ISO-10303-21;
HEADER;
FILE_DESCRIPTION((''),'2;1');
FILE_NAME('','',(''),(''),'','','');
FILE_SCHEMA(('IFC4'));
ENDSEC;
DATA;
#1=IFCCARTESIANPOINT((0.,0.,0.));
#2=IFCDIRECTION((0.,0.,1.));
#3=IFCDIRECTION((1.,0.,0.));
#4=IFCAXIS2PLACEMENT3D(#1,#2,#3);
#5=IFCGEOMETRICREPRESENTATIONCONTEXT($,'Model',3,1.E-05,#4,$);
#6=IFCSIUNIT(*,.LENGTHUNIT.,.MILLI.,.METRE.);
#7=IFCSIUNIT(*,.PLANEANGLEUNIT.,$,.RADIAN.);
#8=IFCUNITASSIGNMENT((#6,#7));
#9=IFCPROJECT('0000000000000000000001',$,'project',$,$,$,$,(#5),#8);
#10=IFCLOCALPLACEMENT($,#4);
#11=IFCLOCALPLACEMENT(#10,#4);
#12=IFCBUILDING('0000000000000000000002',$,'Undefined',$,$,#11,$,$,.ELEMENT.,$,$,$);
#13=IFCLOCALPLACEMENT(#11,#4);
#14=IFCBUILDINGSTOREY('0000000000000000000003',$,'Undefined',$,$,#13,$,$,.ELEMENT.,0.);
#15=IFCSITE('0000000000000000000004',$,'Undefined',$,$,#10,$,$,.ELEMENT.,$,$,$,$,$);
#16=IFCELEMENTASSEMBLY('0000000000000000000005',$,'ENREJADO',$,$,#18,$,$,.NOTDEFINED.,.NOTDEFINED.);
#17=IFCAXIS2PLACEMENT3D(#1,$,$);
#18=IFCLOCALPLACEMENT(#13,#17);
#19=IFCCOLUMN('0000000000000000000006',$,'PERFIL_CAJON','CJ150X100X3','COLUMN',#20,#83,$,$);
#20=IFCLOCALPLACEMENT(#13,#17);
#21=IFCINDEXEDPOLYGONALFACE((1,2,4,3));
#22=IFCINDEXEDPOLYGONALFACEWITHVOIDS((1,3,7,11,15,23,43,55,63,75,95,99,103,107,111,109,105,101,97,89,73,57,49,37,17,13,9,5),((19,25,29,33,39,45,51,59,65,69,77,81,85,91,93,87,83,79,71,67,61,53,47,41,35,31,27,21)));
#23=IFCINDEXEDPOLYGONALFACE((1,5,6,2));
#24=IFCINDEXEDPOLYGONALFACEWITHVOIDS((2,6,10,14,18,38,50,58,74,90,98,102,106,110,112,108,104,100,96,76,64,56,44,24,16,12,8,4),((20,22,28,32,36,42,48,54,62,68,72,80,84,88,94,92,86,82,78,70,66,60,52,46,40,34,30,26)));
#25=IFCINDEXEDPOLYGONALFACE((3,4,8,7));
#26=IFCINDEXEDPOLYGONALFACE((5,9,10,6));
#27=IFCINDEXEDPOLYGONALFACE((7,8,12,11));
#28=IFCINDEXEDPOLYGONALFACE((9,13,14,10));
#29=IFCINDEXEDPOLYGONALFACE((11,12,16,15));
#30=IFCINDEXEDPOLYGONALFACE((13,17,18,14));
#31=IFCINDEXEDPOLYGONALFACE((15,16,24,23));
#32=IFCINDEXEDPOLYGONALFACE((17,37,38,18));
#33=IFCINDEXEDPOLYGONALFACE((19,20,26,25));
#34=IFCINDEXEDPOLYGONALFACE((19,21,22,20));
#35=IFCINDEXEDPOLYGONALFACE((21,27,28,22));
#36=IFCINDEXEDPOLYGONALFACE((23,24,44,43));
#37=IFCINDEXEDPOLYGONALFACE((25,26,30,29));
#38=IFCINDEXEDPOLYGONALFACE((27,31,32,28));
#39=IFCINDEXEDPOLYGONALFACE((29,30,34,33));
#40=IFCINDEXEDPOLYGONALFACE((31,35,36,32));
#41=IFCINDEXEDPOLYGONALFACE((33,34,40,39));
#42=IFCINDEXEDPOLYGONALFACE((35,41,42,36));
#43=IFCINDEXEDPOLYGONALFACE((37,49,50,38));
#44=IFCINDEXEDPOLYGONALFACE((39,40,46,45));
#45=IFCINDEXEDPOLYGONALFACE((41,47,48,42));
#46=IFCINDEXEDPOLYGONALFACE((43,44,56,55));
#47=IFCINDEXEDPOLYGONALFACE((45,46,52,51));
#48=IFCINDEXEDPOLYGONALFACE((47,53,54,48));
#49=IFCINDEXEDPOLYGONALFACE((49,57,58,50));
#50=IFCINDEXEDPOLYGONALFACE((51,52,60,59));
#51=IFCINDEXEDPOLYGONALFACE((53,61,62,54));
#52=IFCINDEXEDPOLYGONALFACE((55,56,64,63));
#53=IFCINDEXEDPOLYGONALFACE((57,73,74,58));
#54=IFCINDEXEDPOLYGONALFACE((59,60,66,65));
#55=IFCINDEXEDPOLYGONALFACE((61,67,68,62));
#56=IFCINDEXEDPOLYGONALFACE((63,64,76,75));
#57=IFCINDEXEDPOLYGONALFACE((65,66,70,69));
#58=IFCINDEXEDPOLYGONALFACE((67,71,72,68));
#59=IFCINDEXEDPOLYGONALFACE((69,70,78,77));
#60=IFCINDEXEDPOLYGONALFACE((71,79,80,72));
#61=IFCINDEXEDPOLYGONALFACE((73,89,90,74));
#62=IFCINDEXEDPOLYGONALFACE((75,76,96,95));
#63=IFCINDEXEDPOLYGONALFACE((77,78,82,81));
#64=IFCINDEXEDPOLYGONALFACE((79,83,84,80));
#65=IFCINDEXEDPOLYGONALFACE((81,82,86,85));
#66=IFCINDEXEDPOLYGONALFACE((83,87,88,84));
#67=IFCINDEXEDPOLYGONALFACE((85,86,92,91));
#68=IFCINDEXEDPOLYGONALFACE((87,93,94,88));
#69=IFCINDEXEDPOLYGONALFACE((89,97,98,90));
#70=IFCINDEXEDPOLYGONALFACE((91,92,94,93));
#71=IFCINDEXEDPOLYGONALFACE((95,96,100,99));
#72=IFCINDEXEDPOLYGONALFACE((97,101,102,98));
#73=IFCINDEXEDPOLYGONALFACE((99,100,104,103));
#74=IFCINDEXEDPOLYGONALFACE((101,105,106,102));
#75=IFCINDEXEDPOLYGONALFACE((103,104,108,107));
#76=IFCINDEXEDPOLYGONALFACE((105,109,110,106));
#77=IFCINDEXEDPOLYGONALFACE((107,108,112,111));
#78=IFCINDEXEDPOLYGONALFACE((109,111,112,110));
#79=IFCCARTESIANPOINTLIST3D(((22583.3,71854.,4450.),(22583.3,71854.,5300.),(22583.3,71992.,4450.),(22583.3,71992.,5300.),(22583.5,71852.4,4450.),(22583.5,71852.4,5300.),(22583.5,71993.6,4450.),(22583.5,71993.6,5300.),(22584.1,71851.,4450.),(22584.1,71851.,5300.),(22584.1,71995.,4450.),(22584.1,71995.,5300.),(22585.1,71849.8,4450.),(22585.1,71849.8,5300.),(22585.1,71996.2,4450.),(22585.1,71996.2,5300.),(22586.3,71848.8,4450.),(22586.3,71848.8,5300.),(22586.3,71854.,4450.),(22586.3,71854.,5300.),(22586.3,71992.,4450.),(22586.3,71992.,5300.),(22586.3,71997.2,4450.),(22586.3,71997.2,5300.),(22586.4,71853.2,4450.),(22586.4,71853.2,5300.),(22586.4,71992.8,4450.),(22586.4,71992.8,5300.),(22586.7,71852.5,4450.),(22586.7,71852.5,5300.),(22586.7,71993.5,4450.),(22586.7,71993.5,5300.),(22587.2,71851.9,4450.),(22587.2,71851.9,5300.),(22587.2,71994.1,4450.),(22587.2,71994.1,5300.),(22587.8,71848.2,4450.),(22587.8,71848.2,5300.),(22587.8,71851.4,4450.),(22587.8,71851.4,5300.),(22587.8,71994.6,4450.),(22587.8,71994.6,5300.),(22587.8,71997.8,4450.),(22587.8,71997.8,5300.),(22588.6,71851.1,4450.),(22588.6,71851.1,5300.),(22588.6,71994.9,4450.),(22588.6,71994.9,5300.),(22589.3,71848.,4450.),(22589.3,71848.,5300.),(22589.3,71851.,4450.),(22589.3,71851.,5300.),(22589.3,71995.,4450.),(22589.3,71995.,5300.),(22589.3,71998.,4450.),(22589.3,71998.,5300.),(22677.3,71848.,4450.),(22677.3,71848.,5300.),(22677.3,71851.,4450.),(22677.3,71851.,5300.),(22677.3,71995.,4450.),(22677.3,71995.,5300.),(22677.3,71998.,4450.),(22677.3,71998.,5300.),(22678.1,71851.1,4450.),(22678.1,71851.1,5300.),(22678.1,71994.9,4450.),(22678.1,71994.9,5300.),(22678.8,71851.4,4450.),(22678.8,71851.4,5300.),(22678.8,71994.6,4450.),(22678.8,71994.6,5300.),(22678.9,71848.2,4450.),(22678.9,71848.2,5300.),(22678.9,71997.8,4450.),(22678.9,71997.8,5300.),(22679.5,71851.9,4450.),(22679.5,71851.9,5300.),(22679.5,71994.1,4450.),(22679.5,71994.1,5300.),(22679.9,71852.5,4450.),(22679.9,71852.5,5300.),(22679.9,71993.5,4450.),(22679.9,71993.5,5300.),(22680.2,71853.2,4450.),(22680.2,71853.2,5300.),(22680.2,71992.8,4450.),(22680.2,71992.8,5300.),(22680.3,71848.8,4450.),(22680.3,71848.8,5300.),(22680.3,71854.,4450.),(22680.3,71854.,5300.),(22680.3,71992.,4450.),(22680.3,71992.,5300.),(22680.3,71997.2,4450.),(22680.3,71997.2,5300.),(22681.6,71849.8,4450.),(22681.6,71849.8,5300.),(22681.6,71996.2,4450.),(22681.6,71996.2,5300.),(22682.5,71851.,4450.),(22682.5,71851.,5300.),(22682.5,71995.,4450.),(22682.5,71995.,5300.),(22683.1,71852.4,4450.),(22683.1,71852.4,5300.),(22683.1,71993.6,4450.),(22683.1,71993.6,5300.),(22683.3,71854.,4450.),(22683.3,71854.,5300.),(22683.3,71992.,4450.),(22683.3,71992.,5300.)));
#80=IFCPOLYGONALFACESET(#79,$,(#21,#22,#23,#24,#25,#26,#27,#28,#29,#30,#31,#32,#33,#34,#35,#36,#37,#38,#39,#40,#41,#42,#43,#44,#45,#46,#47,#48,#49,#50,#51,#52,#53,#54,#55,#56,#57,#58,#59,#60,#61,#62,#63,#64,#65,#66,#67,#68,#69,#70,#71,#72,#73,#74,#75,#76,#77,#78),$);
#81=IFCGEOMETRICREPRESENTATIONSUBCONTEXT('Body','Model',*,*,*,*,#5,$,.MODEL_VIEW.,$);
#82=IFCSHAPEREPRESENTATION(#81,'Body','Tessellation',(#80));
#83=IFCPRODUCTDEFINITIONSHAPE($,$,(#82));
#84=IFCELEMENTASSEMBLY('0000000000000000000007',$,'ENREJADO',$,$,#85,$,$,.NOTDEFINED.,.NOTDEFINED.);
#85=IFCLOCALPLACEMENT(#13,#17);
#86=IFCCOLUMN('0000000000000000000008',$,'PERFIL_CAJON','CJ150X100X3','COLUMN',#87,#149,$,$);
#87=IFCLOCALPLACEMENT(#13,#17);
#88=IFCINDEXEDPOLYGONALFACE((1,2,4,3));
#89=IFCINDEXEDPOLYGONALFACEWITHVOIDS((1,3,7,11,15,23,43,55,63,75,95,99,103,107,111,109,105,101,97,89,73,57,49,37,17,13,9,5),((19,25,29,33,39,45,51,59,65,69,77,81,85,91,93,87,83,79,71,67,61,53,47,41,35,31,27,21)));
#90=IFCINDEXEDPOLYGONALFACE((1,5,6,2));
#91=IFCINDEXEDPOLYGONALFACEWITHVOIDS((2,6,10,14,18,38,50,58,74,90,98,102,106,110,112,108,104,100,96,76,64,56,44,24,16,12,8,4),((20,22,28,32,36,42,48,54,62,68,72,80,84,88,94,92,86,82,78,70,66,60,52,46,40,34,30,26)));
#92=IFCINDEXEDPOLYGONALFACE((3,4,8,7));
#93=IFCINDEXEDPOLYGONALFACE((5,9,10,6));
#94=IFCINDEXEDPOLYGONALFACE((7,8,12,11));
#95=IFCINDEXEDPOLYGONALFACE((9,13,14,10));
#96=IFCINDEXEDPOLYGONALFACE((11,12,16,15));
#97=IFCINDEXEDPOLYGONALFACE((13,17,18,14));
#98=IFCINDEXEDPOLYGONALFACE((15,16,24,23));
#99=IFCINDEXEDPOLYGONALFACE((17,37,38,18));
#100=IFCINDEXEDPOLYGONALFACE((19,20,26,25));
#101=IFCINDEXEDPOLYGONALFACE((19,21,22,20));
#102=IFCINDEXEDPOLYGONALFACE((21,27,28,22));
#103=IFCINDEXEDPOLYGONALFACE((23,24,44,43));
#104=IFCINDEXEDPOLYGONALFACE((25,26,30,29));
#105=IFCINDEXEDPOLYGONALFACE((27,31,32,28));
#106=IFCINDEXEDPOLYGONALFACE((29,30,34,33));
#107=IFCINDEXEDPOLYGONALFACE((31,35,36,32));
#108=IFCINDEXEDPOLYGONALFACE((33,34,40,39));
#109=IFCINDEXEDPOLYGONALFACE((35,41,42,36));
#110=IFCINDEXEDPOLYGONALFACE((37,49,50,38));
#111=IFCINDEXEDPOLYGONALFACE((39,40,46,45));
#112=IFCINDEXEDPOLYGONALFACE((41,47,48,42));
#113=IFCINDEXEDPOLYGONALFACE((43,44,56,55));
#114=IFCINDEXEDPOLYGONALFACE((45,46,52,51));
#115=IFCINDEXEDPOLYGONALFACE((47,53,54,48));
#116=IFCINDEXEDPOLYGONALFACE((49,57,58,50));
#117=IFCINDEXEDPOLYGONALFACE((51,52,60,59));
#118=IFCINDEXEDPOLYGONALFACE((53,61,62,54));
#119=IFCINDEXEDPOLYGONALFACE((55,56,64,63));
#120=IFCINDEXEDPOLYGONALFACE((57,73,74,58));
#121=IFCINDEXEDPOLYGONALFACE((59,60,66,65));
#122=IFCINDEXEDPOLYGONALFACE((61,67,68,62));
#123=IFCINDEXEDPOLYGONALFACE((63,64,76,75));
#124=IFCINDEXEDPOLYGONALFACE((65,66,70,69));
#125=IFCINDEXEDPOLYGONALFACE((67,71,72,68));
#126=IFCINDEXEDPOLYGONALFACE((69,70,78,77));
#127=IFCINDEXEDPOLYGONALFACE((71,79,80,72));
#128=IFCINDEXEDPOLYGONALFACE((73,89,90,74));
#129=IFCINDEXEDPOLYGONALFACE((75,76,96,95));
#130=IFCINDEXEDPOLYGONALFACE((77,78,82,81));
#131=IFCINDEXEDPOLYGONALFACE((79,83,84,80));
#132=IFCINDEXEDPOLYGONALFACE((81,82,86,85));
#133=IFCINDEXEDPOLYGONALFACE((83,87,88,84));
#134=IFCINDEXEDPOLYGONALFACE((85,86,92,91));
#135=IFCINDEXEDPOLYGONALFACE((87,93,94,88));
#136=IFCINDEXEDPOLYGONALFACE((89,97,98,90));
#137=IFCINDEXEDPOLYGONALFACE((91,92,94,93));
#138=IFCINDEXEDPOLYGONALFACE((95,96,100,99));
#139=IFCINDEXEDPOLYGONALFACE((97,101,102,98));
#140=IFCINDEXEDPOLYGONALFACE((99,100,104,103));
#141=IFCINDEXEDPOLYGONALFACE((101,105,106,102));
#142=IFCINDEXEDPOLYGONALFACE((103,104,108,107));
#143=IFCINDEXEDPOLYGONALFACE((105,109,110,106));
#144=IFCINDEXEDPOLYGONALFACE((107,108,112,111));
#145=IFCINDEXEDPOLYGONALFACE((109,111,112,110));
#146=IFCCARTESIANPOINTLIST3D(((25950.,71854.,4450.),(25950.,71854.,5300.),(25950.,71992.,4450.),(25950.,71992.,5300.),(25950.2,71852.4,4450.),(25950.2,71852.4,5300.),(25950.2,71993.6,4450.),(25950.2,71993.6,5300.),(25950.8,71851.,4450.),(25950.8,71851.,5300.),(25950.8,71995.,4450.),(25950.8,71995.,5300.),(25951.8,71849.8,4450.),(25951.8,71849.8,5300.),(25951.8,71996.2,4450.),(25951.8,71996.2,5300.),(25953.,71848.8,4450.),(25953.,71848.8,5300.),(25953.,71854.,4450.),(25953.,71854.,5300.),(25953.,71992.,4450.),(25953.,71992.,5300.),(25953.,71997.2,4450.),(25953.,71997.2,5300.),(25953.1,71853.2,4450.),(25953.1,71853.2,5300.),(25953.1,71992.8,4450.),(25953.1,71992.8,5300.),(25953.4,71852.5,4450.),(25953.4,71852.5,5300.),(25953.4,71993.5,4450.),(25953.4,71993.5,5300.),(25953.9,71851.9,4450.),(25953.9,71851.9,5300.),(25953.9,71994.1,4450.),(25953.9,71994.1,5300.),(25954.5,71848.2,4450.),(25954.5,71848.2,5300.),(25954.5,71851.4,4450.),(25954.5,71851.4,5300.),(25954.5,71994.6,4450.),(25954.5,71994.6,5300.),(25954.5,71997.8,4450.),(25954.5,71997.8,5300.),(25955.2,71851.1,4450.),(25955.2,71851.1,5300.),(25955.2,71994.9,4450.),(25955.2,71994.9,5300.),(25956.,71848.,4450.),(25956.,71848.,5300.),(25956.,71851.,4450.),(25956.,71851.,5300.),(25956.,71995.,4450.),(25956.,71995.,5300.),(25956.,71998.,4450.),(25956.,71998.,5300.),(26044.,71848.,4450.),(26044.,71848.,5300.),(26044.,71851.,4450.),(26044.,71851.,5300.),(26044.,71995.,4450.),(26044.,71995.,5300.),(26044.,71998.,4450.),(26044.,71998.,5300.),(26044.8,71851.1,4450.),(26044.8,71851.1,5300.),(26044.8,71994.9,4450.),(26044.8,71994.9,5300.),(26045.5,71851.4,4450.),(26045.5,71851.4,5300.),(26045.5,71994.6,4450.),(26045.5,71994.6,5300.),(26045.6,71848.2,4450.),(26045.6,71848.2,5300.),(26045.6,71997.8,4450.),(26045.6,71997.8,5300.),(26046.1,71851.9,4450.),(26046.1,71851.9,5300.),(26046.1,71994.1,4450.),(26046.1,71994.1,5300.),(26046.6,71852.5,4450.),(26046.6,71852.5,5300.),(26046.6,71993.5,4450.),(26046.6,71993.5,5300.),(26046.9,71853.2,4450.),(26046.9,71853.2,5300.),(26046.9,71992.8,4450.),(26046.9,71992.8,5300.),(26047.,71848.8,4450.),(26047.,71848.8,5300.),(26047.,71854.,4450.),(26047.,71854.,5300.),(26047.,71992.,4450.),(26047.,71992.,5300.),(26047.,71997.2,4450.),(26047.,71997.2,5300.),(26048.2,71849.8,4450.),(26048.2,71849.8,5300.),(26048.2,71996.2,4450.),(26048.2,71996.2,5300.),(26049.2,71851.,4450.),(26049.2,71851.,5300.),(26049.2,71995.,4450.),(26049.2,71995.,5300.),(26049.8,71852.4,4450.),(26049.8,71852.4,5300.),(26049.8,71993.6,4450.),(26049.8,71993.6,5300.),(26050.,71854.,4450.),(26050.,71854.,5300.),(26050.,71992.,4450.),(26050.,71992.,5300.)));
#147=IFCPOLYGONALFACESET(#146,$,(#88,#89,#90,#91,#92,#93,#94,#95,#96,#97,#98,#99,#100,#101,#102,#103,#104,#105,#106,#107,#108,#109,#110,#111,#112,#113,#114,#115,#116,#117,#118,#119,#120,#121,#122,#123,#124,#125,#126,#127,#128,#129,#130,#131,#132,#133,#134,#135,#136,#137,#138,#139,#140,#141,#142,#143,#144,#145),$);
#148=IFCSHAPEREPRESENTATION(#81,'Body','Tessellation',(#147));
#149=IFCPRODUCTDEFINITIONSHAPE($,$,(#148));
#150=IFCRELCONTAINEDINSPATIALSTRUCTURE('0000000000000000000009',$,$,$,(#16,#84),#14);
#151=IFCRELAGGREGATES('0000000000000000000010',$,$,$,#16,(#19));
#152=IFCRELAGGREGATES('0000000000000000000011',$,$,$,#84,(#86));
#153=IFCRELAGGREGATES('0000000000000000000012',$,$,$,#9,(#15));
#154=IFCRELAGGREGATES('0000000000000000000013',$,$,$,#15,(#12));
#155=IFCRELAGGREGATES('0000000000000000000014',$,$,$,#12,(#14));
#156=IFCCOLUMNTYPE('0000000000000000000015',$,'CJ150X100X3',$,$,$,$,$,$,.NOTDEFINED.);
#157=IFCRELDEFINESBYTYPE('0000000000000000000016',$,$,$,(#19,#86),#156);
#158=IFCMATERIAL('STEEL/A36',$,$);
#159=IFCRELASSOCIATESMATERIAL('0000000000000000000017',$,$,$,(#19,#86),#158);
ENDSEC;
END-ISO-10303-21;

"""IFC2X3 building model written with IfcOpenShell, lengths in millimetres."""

from ifc_helpers import new_model, si_unit, frame, origin_with_axes, origin_2d_with_axis, place, context, subcontext, project, spatial, hollow_rectangle, extrude, clip, halfspace, material, type_object, element, aggregate, save


model = new_model("IFC2X3")

# Units and contexts
model_context = context("Model", 3, precision=1e-05, world=origin_with_axes())
body_context = subcontext(model_context, "Body", "Model", "MODEL_VIEW")
ifc_project = project(units=[si_unit("LENGTHUNIT", "METRE", prefix="MILLI"), si_unit("PLANEANGLEUNIT", "RADIAN")], contexts=[model_context])

# Site, building, storey
site_placement = place(None, origin_with_axes())
site = spatial("IfcSite", under=ifc_project, at=site_placement, Name="Undefined", CompositionType="ELEMENT")
building_placement = place(site_placement, origin_with_axes())
building = spatial("IfcBuilding", under=site, at=building_placement, Name="Undefined", CompositionType="ELEMENT")
storey_placement = place(building_placement, origin_with_axes())
storey = spatial("IfcBuildingStorey", under=building, at=storey_placement, Name="Undefined", CompositionType="ELEMENT", Elevation=0.0)

# Element assemblies, columns
assembly_1_placement = place(storey_placement, origin_with_axes())
assembly_1 = element("IfcElementAssembly", 1, at=assembly_1_placement, inside=storey, Name="ENREJADO", AssemblyPlace="NOTDEFINED", PredefinedType="NOTDEFINED")
ifc_material_1 = material(Name="STEEL/A36")
column_type = type_object("IfcColumnType", Name="CJ150X100X3", PredefinedType="NOTDEFINED")
column_1_placement = place(assembly_1_placement, frame((22633.3, 71923.0, 4450.0), z_axis=(0.0, 0.0, 1.0), x_axis=(0.0, 1.0, 0.0)))
column_1 = element("IfcColumn", 2, at=column_1_placement, type_object=column_type, material=ifc_material_1, Name="PERFIL_CAJON", Description="CJ150X100X3", ObjectType="COLUMN", context=body_context, shape_type="Clipping", body=[
    clip(extrude(hollow_rectangle(XDim=100.0, YDim=150.0, WallThickness=3.0, InnerFilletRadius=3.0, OuterFilletRadius=6.0, at=origin_2d_with_axis()), frame((0.0, 0.0, 850.0), z_axis=(0.0, 0.0, -1.0), x_axis=(0.0, 1.0, 0.0)), (0.0, 0.0, 1.0), 850.0), halfspace(frame((1075.0, 50.0, 850.0), z_axis=(0.0, 0.0, 1.0), x_axis=(0.0, -1.0, 0.0)), False)),
])
assembly_2_placement = place(storey_placement, origin_with_axes())
assembly_2 = element("IfcElementAssembly", 3, at=assembly_2_placement, inside=storey, Name="ENREJADO", AssemblyPlace="NOTDEFINED", PredefinedType="NOTDEFINED")
column_2_placement = place(assembly_2_placement, frame((26000.0, 71923.0, 4450.0), z_axis=(0.0, 0.0, 1.0), x_axis=(0.0, 1.0, 0.0)))
column_2 = element("IfcColumn", 4, at=column_2_placement, type_object=column_type, material=ifc_material_1, Name="PERFIL_CAJON", Description="CJ150X100X3", ObjectType="COLUMN", context=body_context, shape_type="Clipping", body=[
    clip(extrude(hollow_rectangle(XDim=100.0, YDim=150.0, WallThickness=3.0, InnerFilletRadius=3.0, OuterFilletRadius=6.0, at=origin_2d_with_axis()), frame((0.0, 0.0, 850.0), z_axis=(0.0, 0.0, -1.0), x_axis=(0.0, 1.0, 0.0)), (0.0, 0.0, 1.0), 850.0), halfspace(frame((1075.0, 50.0, 850.0), z_axis=(0.0, 0.0, 1.0), x_axis=(0.0, -1.0, 0.0)), False)),
])

aggregate(assembly_1, [column_1])
aggregate(assembly_2, [column_2])

save(model, "model.ifc")
